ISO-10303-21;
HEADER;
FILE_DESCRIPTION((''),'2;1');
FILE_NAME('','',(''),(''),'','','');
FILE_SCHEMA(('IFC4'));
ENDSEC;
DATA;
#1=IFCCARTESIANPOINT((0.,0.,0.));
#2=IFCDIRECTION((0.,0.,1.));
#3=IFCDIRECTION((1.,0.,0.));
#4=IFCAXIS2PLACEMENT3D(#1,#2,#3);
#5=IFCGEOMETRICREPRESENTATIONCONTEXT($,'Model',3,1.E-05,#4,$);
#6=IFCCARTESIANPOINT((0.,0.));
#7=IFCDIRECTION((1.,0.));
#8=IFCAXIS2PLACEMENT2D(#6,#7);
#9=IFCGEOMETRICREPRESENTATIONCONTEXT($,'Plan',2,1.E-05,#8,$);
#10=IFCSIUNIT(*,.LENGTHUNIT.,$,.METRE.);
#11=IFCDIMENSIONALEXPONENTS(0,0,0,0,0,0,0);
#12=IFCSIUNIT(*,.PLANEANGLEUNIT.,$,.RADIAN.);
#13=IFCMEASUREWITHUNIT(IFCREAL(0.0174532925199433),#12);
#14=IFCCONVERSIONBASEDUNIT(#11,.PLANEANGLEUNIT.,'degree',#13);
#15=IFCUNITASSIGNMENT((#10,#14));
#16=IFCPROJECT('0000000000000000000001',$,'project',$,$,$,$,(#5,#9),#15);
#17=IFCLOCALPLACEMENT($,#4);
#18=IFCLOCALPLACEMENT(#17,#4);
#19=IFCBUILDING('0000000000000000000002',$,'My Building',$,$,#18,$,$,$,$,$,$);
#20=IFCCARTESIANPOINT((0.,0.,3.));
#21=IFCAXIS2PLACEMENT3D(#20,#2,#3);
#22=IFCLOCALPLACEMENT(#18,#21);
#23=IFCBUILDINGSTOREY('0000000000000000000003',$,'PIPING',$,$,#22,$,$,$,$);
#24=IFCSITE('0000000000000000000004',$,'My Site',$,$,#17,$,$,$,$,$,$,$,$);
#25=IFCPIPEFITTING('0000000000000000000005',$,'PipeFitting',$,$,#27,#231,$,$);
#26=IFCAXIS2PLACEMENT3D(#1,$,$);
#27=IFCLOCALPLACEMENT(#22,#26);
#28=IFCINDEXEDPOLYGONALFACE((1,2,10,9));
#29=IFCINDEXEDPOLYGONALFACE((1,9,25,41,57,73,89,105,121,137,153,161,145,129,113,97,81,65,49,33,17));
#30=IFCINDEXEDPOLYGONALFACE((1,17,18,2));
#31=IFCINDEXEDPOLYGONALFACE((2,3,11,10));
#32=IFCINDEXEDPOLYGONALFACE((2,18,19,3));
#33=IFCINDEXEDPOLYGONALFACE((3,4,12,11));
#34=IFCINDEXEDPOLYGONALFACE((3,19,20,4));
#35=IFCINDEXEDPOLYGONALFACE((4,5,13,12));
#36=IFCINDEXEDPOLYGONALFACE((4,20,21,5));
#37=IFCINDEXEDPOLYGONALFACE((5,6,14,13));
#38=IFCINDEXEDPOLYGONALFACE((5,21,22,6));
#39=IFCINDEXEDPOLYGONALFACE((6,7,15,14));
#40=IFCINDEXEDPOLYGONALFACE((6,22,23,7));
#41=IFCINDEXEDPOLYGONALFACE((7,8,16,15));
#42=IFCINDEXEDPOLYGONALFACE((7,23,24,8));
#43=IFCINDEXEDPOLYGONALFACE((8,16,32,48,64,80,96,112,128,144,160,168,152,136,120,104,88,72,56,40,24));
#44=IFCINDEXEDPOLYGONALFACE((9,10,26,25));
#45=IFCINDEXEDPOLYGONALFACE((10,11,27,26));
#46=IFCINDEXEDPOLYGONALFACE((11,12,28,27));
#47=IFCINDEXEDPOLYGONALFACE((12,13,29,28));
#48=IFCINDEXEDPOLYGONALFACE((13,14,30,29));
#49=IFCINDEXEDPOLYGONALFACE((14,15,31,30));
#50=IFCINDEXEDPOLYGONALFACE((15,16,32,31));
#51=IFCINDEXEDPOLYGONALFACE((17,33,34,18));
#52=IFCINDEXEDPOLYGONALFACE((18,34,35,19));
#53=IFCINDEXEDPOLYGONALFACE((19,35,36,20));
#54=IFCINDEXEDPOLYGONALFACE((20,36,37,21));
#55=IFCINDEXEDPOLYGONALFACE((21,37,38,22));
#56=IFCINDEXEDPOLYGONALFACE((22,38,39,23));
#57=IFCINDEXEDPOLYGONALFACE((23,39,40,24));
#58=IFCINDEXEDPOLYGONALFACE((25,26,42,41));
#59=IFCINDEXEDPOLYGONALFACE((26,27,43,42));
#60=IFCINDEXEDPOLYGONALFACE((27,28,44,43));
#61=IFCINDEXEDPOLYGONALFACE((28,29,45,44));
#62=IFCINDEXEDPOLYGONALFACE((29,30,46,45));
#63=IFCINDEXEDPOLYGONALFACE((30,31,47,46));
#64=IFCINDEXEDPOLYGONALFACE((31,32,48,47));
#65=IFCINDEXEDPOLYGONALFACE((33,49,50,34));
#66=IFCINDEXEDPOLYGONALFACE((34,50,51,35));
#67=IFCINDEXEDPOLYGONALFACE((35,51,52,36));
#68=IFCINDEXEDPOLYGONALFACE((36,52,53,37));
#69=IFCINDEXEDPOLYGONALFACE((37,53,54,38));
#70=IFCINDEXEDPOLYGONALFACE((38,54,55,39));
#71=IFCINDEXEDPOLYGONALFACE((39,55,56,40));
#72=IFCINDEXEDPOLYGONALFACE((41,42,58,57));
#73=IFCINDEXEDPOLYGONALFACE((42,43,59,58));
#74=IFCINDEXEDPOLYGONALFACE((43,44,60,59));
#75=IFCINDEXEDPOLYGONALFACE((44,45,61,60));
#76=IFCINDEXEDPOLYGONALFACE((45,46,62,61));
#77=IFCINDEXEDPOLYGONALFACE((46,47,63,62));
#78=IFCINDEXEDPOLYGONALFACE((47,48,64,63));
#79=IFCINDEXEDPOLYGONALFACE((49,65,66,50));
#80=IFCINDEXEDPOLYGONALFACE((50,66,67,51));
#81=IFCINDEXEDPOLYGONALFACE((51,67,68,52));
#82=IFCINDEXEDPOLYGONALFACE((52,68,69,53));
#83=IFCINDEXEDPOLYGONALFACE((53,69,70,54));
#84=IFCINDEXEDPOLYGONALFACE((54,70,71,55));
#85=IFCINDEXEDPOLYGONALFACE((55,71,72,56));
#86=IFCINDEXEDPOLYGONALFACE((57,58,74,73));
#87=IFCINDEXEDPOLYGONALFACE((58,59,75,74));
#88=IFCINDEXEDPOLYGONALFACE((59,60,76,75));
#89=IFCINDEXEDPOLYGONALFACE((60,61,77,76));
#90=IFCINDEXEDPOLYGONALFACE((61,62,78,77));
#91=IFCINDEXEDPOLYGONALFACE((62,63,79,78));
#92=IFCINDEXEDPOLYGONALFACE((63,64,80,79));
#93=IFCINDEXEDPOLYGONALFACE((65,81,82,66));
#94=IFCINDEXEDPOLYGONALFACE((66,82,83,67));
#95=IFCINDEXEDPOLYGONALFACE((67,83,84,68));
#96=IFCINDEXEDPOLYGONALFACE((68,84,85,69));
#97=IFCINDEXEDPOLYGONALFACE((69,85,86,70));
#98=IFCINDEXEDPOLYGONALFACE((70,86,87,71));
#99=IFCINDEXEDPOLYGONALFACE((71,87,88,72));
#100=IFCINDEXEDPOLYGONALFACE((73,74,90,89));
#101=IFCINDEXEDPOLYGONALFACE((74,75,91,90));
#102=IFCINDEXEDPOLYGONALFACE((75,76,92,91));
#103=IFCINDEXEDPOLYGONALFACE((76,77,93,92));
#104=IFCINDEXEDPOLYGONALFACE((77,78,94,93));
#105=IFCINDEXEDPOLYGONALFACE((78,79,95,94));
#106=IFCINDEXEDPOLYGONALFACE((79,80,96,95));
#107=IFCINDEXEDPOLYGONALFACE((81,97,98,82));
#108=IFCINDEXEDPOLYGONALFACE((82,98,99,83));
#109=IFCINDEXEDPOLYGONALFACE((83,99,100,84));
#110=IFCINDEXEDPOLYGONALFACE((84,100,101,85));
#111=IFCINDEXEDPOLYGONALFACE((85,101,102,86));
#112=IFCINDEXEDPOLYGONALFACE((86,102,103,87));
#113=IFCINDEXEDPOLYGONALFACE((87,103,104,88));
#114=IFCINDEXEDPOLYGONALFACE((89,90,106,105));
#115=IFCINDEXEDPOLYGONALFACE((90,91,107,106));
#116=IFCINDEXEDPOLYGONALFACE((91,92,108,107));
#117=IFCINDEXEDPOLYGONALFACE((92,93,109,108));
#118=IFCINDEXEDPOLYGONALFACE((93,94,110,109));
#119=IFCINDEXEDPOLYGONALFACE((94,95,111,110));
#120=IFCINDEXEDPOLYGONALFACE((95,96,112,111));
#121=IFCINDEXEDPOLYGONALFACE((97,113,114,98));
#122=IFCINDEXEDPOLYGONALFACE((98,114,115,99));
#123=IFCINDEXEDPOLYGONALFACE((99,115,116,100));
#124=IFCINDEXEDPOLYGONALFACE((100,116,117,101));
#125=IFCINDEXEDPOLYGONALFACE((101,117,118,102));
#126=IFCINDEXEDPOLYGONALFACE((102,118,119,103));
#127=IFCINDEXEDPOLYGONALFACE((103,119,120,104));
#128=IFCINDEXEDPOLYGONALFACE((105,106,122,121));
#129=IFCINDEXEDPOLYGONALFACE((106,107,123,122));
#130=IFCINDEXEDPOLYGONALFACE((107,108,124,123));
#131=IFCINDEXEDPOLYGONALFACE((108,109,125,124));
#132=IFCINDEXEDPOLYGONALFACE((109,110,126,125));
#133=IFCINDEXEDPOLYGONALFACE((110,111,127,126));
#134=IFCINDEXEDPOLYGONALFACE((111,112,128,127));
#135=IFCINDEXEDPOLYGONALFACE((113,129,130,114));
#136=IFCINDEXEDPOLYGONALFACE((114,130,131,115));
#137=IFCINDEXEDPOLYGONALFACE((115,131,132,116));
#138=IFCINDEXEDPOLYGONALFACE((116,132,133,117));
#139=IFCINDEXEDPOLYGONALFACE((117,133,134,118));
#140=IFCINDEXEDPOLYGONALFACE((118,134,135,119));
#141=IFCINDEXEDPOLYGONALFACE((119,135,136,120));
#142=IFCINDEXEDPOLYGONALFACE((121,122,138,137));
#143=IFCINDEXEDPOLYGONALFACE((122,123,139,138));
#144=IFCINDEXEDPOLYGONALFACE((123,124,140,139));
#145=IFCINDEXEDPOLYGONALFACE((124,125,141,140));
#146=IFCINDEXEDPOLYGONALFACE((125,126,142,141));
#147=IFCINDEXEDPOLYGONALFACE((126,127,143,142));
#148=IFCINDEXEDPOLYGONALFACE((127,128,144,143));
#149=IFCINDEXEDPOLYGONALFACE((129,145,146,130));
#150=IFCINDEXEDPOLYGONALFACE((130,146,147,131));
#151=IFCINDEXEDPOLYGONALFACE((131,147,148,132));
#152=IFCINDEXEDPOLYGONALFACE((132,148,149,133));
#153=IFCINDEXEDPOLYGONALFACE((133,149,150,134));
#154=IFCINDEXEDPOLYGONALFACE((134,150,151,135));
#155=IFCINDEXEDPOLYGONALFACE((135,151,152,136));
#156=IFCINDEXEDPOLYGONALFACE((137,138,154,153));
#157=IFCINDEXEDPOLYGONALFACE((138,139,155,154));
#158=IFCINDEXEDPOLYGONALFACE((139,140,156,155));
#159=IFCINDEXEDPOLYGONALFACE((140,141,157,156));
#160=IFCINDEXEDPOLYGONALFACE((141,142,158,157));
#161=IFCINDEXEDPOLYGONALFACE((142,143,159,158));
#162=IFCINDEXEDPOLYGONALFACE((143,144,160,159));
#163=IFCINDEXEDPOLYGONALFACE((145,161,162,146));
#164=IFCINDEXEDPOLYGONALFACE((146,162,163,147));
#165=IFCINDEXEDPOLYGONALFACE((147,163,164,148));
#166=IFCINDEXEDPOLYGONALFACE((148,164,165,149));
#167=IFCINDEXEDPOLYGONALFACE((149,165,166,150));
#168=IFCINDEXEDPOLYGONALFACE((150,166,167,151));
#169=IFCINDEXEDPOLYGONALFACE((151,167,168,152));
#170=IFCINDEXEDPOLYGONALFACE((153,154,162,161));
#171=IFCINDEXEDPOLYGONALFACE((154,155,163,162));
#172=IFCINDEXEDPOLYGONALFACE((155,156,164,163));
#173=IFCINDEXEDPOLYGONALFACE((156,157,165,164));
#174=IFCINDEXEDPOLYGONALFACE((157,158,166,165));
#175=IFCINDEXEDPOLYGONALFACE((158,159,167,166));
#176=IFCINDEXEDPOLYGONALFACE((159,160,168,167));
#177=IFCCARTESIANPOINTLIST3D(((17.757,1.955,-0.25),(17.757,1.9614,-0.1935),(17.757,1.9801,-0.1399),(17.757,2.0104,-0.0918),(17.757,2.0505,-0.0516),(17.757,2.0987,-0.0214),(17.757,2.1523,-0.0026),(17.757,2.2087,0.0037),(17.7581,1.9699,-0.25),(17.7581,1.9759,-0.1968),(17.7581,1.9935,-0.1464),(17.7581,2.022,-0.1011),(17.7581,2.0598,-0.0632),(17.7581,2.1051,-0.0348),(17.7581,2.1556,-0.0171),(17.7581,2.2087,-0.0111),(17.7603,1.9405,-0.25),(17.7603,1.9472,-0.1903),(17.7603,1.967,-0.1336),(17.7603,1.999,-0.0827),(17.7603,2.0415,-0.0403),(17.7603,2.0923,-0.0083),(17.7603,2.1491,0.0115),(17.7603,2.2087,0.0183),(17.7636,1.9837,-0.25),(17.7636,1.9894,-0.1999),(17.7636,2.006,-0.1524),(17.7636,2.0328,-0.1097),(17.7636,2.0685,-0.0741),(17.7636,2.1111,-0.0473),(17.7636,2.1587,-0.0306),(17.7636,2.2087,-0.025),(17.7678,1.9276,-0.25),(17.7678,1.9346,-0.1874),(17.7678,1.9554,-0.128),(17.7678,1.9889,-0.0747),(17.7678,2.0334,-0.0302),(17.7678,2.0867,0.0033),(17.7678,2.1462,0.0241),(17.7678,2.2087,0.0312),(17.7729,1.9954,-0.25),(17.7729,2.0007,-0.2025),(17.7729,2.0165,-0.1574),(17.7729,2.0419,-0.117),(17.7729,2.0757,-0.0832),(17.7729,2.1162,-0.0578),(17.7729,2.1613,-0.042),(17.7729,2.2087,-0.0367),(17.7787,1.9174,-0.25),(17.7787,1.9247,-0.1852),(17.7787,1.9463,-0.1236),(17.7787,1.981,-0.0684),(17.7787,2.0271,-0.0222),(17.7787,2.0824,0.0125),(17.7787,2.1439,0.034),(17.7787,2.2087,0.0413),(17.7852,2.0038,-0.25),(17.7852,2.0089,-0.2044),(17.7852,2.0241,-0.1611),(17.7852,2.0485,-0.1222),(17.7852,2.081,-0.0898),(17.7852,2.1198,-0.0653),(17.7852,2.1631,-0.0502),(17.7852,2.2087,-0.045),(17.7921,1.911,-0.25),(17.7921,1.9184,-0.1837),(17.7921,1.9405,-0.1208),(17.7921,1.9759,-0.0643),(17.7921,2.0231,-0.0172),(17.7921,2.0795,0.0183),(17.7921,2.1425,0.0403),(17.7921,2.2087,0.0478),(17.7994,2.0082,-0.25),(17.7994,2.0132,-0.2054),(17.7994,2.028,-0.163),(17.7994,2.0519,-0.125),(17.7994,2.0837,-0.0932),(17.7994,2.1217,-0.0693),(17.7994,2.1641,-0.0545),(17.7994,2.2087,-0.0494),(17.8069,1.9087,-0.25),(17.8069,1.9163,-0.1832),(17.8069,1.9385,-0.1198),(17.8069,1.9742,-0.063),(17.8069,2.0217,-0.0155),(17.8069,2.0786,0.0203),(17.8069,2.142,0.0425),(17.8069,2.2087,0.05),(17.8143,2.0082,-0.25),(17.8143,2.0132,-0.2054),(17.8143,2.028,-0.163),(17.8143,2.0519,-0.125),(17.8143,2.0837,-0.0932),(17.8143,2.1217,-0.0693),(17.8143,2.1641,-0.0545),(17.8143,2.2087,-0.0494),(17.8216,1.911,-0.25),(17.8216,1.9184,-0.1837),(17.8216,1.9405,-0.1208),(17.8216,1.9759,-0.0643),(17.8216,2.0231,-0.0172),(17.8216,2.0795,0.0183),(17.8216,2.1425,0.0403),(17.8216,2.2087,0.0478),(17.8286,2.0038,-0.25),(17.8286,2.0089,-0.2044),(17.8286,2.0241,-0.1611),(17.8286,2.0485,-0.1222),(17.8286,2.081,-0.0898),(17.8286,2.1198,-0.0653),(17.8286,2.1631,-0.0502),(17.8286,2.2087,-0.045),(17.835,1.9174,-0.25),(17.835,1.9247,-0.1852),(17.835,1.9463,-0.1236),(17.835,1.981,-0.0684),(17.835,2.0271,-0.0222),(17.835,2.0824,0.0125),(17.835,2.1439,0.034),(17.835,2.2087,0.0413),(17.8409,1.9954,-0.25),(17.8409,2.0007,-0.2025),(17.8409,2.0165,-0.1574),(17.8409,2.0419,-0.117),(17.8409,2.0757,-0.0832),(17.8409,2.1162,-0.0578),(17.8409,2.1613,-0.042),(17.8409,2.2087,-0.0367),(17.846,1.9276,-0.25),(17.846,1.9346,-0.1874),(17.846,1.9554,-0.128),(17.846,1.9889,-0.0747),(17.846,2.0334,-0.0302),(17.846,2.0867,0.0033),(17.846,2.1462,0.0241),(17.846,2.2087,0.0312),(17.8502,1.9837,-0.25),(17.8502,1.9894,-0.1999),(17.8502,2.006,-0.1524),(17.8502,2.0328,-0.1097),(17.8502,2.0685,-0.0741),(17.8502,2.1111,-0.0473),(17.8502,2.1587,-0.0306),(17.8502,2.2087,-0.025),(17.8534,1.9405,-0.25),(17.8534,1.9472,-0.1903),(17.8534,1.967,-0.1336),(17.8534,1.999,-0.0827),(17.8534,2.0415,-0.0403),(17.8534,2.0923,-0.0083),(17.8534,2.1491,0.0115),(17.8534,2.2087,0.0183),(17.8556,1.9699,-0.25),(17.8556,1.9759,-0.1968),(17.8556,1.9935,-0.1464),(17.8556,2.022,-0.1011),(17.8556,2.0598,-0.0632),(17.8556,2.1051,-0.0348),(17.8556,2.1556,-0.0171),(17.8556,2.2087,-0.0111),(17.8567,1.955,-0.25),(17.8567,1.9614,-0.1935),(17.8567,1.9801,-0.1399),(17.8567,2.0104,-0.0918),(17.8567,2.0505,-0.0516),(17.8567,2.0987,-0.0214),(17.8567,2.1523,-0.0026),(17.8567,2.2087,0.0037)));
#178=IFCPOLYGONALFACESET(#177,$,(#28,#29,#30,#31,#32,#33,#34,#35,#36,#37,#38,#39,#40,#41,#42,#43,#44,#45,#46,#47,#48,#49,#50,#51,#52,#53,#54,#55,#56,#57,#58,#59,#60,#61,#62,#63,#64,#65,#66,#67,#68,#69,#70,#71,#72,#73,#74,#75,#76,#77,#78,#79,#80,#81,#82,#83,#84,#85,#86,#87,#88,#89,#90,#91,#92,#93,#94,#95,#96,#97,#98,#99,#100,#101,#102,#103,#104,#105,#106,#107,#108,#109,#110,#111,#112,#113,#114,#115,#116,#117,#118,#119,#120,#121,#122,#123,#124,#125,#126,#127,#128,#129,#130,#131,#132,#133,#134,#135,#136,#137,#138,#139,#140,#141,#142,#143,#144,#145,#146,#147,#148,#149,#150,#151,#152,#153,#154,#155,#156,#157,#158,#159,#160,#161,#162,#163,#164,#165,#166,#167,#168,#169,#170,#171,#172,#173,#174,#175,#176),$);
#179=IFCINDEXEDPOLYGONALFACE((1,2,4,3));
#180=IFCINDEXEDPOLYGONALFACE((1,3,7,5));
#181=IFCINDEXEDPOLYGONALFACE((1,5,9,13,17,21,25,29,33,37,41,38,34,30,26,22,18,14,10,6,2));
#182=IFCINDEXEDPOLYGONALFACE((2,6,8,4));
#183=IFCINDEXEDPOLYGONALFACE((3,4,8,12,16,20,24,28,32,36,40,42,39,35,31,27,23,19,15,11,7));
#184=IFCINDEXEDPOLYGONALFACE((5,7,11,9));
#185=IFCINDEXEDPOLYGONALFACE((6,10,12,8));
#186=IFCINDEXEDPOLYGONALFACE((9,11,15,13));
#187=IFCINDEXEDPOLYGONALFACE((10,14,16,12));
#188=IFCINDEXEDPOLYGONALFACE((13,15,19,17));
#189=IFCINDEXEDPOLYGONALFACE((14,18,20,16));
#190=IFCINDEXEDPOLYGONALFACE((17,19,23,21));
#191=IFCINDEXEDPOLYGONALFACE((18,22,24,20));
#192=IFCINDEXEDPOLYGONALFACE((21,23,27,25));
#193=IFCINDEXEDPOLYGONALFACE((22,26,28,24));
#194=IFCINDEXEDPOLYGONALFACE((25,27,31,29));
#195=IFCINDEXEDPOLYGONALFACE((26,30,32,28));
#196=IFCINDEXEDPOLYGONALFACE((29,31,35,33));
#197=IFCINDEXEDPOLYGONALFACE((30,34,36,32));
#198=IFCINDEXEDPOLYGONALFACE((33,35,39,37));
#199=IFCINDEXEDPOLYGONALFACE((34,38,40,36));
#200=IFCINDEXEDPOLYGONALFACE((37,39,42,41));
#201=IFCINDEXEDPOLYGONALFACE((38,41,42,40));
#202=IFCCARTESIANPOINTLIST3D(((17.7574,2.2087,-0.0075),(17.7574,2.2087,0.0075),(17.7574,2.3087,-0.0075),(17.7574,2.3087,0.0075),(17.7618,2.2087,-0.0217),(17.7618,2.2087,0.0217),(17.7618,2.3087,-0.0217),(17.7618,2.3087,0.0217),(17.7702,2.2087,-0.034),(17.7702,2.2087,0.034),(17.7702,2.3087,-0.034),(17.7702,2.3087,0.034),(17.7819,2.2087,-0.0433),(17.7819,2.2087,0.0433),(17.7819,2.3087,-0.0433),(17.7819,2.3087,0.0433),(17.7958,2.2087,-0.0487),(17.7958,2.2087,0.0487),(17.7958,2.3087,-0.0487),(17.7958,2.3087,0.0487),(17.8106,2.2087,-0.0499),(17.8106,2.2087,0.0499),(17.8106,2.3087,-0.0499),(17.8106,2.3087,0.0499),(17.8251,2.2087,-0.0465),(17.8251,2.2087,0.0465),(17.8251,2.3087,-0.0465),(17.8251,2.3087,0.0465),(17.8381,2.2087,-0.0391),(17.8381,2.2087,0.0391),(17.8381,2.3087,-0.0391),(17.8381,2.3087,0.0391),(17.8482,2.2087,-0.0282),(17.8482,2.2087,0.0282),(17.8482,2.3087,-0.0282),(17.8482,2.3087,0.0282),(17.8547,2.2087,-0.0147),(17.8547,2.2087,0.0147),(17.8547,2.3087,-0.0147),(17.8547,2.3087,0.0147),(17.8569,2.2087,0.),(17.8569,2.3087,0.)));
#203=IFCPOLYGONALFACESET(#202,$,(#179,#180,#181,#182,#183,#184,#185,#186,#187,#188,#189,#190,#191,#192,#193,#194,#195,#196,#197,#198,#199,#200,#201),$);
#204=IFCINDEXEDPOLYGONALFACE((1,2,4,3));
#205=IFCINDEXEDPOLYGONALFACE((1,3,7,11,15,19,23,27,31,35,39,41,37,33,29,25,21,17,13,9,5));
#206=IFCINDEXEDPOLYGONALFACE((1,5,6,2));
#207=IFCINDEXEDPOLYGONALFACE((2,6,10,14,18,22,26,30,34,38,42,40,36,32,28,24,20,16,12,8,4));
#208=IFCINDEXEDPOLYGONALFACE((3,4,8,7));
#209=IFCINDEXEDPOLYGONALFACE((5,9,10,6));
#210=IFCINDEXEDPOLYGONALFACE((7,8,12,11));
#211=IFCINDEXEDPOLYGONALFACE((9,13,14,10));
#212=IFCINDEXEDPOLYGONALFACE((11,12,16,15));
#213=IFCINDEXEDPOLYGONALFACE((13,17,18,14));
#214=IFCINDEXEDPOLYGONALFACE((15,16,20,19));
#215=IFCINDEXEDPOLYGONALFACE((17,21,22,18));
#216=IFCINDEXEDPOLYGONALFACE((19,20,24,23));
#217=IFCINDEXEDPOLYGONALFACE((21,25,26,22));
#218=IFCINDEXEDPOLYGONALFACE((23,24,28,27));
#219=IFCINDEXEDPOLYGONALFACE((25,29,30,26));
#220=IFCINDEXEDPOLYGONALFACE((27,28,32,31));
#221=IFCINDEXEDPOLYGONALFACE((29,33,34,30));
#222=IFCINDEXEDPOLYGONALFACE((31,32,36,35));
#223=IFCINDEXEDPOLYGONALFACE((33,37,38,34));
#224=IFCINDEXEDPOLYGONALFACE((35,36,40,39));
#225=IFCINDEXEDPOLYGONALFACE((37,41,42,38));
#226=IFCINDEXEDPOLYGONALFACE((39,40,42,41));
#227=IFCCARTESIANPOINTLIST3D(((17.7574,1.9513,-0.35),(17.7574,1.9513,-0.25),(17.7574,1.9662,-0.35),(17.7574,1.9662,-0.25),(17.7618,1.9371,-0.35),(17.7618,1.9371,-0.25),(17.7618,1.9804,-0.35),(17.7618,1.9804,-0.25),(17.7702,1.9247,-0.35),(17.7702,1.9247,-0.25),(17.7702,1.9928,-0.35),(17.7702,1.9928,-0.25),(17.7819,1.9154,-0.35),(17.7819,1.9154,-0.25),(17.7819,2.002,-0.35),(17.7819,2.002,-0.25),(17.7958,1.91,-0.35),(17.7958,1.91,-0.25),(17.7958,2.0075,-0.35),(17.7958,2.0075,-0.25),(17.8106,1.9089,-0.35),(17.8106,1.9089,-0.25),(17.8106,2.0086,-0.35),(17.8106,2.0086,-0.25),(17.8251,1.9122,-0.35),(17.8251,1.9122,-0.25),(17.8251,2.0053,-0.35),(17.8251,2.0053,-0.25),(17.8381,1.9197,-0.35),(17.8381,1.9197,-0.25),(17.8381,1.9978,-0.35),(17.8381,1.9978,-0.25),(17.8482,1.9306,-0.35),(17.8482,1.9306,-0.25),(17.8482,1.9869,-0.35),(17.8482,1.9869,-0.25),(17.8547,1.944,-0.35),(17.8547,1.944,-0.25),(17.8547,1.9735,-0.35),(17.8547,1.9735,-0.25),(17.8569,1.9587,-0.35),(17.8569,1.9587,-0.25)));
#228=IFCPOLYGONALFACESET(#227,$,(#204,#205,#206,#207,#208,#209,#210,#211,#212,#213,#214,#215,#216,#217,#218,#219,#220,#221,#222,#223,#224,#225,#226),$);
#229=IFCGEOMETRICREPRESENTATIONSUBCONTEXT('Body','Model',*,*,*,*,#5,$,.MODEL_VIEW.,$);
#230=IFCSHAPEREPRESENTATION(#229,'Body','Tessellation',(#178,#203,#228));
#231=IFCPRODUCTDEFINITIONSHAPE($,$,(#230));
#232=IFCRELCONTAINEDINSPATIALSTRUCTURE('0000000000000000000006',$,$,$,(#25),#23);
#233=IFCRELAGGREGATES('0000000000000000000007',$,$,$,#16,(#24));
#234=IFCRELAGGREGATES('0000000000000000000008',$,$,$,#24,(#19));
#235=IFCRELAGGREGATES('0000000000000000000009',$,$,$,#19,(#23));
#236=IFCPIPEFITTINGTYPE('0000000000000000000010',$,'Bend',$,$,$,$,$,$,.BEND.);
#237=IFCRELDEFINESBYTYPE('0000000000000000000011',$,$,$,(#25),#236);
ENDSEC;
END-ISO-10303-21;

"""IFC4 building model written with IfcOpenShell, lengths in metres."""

from ifc_helpers import new_model, entity, si_unit, converted_unit, frame, origin_with_axes, origin_2d_with_axis, place, context, subcontext, project, spatial, line, indexed_curve, circle, outline, extrude, source, transform, mapped, type_object, type_shapes, element, save


model = new_model("IFC4")

# Units and contexts
model_context = context("Model", 3, precision=1e-05, world=origin_with_axes())
plan_context = context("Plan", 2, precision=1e-05, world=origin_2d_with_axis())
body_context = subcontext(model_context, "Body", "Model", "MODEL_VIEW")
ifc_project = project(units=[si_unit("LENGTHUNIT", "METRE"), converted_unit("PLANEANGLEUNIT", "degree", entity("IfcReal", 0.0174532925199433), si_unit("PLANEANGLEUNIT", "RADIAN"), dimensions=[0, 0, 0, 0, 0, 0, 0])], contexts=[model_context, plan_context])

# Site, building, storey
site_placement = place(None, origin_with_axes())
site = spatial("IfcSite", under=ifc_project, at=site_placement, Name="My Site")
building_placement = place(site_placement, origin_with_axes())
building = spatial("IfcBuilding", under=site, at=building_placement, Name="My Building")
storey_placement = place(building_placement, frame((0.0, 0.0, 3.0), z_axis=(0.0, 0.0, 1.0), x_axis=(1.0, 0.0, 0.0)))
storey = spatial("IfcBuildingStorey", under=building, at=storey_placement, Name="PIPING")

# Pipe fitting, opening
pipe_fitting_type = type_object("IfcPipeFittingType", Name="Bend", PredefinedType="BEND")
shared_shape = source(origin_with_axes(), body_context, "Body", "SolidModel", [
    entity("IfcSweptDiskSolid", entity("IfcIndexedPolyCurve", entity("IfcCartesianPointList3D", [[0.0, 0.0, 0.1], [0.0, -0.0732, 0.2768], [0.0, -0.25, 0.35]]), [entity("IfcArcIndex", [1, 2, 3])]), 0.05),
    extrude(circle(Radius=0.05), origin_with_axes(), (0.0, 0.0, 1.0), 0.1),
    extrude(circle(Radius=0.05), frame((0.0, -0.25, 0.35), z_axis=(0.0, -1.0, 0.0), x_axis=(1.0, 0.0, 0.0)), (0.0, 0.0, 1.0), 0.1),
])
type_shapes(pipe_fitting_type, [shared_shape])
pipe_fitting_1_placement = place(storey_placement, frame((17.8069, 2.3087, 0.0), z_axis=(0.0, -1.0, 0.0), x_axis=(1.0, 0.0, 0.0)))
pipe_fitting_1 = element("IfcPipeFitting", 1, at=pipe_fitting_1_placement, inside=storey, type_object=pipe_fitting_type, Name="PipeFitting", context=body_context, shape_type="MappedRepresentation", body=[
    mapped(shared_shape, transform((0.0, 0.0, 0.0), x_axis=(1.0, 0.0, 0.0), y_axis=(0.0, 1.0, 0.0), z_axis=(0.0, 0.0, 1.0), scale=1.0)),
])
opening_1_placement = place(pipe_fitting_1_placement, frame((-17.8069, -3.0, 2.3087), z_axis=(0.0, 1.0, 0.0), x_axis=(1.0, 0.0, 0.0)))
element("IfcOpeningElement", 2, at=opening_1_placement, cuts=pipe_fitting_1, PredefinedType="OPENING", context=body_context, shape_type="SweptSolid", body=[
    extrude(outline(indexed_curve([(0.0, 0.0), (0.5, 0.0), (0.5, 0.5), (0.0, 0.5)], segments=[line(1, 2, 3, 4, 1)])), origin_with_axes(), (0.0, 0.0, 1.0), 0.5),
])

save(model, "model.ifc")
